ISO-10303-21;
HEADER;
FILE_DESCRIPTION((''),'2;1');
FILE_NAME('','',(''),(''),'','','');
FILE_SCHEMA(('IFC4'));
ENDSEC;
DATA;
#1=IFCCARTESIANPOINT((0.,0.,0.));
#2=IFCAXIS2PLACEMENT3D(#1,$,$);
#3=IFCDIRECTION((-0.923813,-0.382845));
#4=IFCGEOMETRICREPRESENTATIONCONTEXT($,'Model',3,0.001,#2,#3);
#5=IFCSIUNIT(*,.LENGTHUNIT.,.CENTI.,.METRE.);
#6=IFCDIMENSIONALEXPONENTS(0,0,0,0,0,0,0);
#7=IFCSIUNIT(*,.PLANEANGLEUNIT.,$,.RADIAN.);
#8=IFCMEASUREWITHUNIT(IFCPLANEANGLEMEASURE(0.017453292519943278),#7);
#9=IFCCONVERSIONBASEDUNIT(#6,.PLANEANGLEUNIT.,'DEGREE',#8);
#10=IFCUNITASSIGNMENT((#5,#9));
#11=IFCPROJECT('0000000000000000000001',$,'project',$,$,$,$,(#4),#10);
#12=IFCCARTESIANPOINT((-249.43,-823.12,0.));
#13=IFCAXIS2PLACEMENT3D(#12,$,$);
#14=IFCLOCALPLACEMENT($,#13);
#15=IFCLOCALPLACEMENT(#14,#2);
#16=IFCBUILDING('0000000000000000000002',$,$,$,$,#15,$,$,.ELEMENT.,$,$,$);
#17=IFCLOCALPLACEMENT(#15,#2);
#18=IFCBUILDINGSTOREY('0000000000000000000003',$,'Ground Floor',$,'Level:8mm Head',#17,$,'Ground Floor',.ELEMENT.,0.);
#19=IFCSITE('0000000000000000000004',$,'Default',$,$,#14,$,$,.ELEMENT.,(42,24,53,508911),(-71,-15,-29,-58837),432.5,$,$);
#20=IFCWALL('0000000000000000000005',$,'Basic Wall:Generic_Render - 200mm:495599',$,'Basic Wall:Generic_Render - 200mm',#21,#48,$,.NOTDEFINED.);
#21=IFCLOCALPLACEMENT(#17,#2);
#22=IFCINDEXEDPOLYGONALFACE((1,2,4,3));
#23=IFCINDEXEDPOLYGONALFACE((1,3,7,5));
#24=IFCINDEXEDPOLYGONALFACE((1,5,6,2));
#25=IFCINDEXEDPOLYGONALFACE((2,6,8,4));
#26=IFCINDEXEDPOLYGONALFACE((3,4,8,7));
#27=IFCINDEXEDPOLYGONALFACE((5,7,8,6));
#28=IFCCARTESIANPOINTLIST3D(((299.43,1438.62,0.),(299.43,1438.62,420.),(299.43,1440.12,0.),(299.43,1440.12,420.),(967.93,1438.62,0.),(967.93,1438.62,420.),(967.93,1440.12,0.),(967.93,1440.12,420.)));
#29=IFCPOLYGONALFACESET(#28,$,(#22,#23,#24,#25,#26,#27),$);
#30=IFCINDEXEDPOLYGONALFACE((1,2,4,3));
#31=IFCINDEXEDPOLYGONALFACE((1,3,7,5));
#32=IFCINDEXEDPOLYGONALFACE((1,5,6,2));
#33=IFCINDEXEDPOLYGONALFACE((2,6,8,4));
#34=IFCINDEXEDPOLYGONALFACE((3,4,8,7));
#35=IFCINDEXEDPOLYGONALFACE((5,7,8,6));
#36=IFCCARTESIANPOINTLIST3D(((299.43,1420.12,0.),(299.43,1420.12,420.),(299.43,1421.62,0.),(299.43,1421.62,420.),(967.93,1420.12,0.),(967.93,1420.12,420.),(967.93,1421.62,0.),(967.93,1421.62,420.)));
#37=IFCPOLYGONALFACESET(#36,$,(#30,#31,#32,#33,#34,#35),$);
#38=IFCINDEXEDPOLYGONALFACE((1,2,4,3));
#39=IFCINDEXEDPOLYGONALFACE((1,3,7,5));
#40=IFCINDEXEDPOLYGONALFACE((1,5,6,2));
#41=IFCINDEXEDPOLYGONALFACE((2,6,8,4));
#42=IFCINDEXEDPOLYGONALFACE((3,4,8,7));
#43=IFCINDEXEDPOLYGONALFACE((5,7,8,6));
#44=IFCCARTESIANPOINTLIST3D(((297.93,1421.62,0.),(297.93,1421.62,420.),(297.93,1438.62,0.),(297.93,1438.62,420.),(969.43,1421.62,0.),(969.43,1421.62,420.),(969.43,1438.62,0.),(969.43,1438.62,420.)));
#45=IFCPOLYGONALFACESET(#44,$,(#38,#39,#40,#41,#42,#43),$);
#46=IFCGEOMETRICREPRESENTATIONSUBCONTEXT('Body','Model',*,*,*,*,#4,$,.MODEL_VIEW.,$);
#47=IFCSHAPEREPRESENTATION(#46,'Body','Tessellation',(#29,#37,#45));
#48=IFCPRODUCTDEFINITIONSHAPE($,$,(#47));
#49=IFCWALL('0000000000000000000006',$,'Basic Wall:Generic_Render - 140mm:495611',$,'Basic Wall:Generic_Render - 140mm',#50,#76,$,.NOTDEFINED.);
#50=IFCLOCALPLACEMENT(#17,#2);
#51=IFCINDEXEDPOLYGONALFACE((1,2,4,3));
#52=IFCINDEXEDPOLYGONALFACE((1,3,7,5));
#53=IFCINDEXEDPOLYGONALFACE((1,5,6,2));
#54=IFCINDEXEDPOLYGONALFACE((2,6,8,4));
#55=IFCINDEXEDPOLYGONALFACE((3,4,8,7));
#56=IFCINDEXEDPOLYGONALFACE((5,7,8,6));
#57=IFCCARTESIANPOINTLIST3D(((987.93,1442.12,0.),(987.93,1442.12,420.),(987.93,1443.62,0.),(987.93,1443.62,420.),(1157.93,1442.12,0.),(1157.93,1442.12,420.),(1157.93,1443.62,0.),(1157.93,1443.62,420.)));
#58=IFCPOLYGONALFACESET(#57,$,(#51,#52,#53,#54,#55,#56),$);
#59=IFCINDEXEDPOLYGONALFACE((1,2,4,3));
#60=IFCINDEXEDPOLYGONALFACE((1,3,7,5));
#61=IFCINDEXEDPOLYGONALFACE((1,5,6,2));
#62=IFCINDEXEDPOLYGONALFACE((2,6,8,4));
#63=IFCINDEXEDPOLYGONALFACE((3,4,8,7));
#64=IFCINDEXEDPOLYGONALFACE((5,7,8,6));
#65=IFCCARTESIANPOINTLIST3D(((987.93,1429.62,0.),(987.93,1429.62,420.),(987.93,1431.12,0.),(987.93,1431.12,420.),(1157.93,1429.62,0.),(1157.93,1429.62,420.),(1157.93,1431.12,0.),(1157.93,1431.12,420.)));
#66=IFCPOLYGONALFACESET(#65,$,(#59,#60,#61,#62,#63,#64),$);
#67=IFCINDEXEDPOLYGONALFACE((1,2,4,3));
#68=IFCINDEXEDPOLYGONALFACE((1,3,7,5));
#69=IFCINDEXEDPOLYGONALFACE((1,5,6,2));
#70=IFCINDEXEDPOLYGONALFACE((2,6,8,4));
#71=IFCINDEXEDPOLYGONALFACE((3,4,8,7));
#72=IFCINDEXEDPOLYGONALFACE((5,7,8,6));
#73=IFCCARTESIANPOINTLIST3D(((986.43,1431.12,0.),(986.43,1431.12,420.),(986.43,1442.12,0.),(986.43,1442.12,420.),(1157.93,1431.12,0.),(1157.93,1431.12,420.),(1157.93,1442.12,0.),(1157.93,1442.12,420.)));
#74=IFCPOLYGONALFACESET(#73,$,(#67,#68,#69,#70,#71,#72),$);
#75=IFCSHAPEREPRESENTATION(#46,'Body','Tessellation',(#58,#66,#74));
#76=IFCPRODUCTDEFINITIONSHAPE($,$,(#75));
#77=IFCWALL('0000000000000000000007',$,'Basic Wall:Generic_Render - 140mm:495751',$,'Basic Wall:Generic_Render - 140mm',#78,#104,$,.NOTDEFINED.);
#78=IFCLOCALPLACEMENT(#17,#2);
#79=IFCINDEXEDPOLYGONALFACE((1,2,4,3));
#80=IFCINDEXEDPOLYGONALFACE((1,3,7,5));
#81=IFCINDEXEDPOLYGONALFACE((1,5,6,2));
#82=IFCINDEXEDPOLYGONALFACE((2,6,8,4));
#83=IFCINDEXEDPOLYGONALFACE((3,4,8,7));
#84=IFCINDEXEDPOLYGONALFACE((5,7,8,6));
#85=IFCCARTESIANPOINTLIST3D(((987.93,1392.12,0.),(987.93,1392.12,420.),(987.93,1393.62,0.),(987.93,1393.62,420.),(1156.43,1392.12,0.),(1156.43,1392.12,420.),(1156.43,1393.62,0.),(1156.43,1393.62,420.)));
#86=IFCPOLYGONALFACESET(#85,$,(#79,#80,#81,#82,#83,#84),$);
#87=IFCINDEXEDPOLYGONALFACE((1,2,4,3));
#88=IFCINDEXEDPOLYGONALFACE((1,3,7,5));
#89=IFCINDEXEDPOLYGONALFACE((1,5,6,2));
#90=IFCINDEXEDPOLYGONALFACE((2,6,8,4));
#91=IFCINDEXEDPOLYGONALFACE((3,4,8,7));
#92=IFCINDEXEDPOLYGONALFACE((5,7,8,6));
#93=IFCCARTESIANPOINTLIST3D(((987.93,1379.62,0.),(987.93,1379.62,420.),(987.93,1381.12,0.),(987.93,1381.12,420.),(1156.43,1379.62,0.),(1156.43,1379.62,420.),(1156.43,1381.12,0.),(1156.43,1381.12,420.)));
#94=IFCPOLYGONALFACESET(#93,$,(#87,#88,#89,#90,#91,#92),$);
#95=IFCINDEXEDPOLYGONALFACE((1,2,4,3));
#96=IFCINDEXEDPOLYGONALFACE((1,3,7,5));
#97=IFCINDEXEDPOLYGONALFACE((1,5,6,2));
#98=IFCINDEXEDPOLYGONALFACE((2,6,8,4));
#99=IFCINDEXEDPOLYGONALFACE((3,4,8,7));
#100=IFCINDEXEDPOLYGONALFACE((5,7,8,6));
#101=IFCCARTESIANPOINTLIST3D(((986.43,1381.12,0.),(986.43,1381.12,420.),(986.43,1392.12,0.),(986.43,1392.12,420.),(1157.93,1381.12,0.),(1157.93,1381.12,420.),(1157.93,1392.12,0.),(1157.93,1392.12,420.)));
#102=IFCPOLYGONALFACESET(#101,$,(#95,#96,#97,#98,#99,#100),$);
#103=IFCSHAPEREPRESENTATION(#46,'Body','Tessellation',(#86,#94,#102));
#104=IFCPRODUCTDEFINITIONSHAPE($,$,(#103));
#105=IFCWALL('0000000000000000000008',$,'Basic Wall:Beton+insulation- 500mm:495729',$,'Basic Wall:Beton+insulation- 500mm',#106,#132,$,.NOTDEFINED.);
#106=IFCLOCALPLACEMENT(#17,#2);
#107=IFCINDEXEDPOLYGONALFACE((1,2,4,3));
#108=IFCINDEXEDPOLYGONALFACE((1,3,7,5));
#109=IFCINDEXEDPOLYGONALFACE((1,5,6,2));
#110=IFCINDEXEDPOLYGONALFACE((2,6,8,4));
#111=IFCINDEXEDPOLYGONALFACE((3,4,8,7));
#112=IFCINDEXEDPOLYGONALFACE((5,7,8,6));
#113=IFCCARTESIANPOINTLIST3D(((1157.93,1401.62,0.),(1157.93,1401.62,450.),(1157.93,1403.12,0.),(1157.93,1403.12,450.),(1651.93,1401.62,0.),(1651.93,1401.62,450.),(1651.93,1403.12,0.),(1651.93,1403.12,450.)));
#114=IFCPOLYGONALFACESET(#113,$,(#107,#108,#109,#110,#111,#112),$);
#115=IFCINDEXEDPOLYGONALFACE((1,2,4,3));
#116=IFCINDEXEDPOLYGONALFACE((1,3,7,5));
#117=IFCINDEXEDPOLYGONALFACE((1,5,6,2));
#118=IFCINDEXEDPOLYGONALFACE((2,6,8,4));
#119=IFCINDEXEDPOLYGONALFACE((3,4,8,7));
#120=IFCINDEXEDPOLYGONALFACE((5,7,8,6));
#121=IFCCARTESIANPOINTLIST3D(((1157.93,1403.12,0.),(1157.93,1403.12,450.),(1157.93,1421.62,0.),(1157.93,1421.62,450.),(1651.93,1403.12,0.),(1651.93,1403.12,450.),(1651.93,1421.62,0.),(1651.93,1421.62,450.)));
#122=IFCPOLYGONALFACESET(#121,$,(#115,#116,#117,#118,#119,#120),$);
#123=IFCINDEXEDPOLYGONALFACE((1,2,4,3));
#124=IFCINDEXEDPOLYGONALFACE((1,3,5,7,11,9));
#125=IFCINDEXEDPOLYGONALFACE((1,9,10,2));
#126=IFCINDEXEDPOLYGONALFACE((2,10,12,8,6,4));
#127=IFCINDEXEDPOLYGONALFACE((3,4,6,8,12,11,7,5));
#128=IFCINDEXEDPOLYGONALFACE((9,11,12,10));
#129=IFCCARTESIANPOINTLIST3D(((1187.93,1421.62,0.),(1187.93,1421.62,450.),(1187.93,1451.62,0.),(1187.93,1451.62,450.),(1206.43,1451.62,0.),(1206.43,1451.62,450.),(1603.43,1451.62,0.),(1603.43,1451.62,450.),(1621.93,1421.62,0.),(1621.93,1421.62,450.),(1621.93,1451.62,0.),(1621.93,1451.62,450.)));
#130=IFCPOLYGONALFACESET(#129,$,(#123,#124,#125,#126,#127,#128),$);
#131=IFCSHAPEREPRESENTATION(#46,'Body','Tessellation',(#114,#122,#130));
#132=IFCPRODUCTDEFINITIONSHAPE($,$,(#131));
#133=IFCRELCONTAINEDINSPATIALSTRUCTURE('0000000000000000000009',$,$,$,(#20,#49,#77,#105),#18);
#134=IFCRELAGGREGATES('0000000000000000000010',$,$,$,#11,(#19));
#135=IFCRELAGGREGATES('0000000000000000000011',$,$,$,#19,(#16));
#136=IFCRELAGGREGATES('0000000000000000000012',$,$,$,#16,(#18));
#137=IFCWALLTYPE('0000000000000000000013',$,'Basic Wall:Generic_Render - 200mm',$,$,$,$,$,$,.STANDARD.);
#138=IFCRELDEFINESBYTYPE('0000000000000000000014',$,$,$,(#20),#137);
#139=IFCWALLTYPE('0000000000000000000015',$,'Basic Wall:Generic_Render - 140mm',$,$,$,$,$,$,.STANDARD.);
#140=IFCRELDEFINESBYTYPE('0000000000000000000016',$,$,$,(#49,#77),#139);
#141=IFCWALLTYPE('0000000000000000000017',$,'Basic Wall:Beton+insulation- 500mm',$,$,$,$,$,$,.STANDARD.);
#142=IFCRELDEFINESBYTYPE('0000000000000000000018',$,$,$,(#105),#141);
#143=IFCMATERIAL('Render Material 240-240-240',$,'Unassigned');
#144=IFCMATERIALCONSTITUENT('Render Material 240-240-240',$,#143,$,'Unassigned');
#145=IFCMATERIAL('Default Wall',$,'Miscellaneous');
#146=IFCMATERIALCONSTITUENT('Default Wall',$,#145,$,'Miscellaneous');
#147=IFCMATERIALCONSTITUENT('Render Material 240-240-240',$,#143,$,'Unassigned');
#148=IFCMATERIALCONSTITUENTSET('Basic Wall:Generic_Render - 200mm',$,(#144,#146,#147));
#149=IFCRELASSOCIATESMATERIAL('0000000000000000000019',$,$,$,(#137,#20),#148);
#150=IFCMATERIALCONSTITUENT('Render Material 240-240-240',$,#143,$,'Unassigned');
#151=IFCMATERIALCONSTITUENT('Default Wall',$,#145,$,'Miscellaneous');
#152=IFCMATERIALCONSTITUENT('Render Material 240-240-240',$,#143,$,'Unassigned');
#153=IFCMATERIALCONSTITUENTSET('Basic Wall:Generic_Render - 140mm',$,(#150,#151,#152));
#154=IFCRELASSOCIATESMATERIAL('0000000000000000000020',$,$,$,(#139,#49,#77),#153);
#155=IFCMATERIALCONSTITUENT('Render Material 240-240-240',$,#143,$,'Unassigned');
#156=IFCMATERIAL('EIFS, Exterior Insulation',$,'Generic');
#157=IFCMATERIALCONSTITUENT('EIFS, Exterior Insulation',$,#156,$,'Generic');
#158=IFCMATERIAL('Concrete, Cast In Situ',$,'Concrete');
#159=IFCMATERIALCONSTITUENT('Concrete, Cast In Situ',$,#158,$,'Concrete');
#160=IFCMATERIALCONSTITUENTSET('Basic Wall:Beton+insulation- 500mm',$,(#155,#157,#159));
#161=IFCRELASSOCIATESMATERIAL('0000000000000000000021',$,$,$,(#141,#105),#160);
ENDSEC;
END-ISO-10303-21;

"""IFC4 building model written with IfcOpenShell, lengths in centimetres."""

from ifc_helpers import new_model, entity, si_unit, converted_unit, direction, frame, origin, place, context, subcontext, project, spatial, indexed_curve, outline, extrude, material, constituent, constituent_set, type_object, element, save


model = new_model("IFC4")

# Units and contexts
model_context = context("Model", 3, precision=0.001, world=origin(), true_north=direction((-0.923813, -0.382845)))
body_context = subcontext(model_context, "Body", "Model", "MODEL_VIEW")
ifc_project = project(units=[si_unit("LENGTHUNIT", "METRE", prefix="CENTI"), converted_unit("PLANEANGLEUNIT", "DEGREE", entity("IfcPlaneAngleMeasure", 0.017453292519943278), si_unit("PLANEANGLEUNIT", "RADIAN"), dimensions=[0, 0, 0, 0, 0, 0, 0])], contexts=[model_context])

# Site, building, storey
site_placement = place(None, frame((-249.43, -823.12, 0.0)))
site = spatial("IfcSite", under=ifc_project, at=site_placement, Name="Default", CompositionType="ELEMENT", RefLatitude=(42, 24, 53, 508911), RefLongitude=(-71, -15, -29, -58837), RefElevation=432.5)
building_placement = place(site_placement, origin())
building = spatial("IfcBuilding", under=site, at=building_placement, CompositionType="ELEMENT")
storey_placement = place(building_placement, origin())
storey = spatial("IfcBuildingStorey", under=building, at=storey_placement, Name="Ground Floor", ObjectType="Level:8mm Head", LongName="Ground Floor", CompositionType="ELEMENT", Elevation=0.0)

# Wall
ifc_material_1 = material(Name="Concrete, Cast In Situ", Category="Concrete")
ifc_material_2 = material(Name="Render Material 240-240-240", Category="Unassigned")
ifc_material_3 = material(Name="Default Wall", Category="Miscellaneous")
ifc_material_4 = material(Name="EIFS, Exterior Insulation", Category="Generic")
ifc_constituent_1 = constituent(ifc_material_2, Name="Render Material 240-240-240", Category="Unassigned")
ifc_constituent_2 = constituent(ifc_material_3, Name="Default Wall", Category="Miscellaneous")
ifc_constituent_3 = constituent(ifc_material_2, Name="Render Material 240-240-240", Category="Unassigned")
ifc_constituent_set_1 = constituent_set(constituents=[ifc_constituent_1, ifc_constituent_2, ifc_constituent_3], Name="Basic Wall:Generic_Render - 200mm")
wall_type_1 = type_object("IfcWallType", Name="Basic Wall:Generic_Render - 200mm", PredefinedType="STANDARD", material=ifc_constituent_set_1)
wall_1_placement = place(storey_placement, frame((967.93, 1430.12, 0.0), z_axis=(0.0, 0.0, 1.0), x_axis=(-1.0, 0.0, 0.0)))
element("IfcWall", 1, at=wall_1_placement, inside=storey, type_object=wall_type_1, material=ifc_constituent_set_1, Name="Basic Wall:Generic_Render - 200mm:495599", ObjectType="Basic Wall:Generic_Render - 200mm", PredefinedType="NOTDEFINED", context=body_context, shape_type="SweptSolid", body=[
    extrude(outline(indexed_curve([(-0.75, -334.25), (0.75, -334.25), (0.75, 334.25), (-0.75, 334.25), (-0.75, -334.25)], self_intersect=False)), frame((334.25, -9.25, 0.0), z_axis=(0.0, 0.0, 1.0), x_axis=(0.0, 1.0, 0.0)), (0.0, 0.0, 1.0), 420.0),
    extrude(outline(indexed_curve([(-0.75, -334.25), (0.75, -334.25), (0.75, 334.25), (-0.75, 334.25), (-0.75, -334.25)], self_intersect=False)), frame((334.25, 9.25, 0.0), z_axis=(0.0, 0.0, 1.0), x_axis=(0.0, -1.0, 0.0)), (0.0, 0.0, 1.0), 420.0),
    extrude(outline(indexed_curve([(-335.75, -8.5), (335.75, -8.5), (335.75, 8.5), (-335.75, 8.5), (-335.75, -8.5)], self_intersect=False)), frame((334.25, 0.0, 0.0)), (0.0, 0.0, 1.0), 420.0),
])

# Walls
ifc_constituent_4 = constituent(ifc_material_2, Name="Render Material 240-240-240", Category="Unassigned")
ifc_constituent_5 = constituent(ifc_material_3, Name="Default Wall", Category="Miscellaneous")
ifc_constituent_6 = constituent(ifc_material_2, Name="Render Material 240-240-240", Category="Unassigned")
ifc_constituent_set_2 = constituent_set(constituents=[ifc_constituent_4, ifc_constituent_5, ifc_constituent_6], Name="Basic Wall:Generic_Render - 140mm")
wall_type_2 = type_object("IfcWallType", Name="Basic Wall:Generic_Render - 140mm", PredefinedType="STANDARD", material=ifc_constituent_set_2)
wall_2_placement = place(storey_placement, frame((1157.93, 1436.62, 0.0), z_axis=(0.0, 0.0, 1.0), x_axis=(-1.0, 0.0, 0.0)))
element("IfcWall", 2, at=wall_2_placement, inside=storey, type_object=wall_type_2, material=ifc_constituent_set_2, Name="Basic Wall:Generic_Render - 140mm:495611", ObjectType="Basic Wall:Generic_Render - 140mm", PredefinedType="NOTDEFINED", context=body_context, shape_type="SweptSolid", body=[
    extrude(outline(indexed_curve([(-0.75, -85.0), (0.75, -85.0), (0.75, 85.0), (-0.75, 85.0), (-0.75, -85.0)], self_intersect=False)), frame((85.0, -6.25, 0.0), z_axis=(0.0, 0.0, 1.0), x_axis=(0.0, 1.0, 0.0)), (0.0, 0.0, 1.0), 420.0),
    extrude(outline(indexed_curve([(-0.75, -85.0), (0.75, -85.0), (0.75, 85.0), (-0.75, 85.0), (-0.75, -85.0)], self_intersect=False)), frame((85.0, 6.25, 0.0), z_axis=(0.0, 0.0, 1.0), x_axis=(0.0, -1.0, 0.0)), (0.0, 0.0, 1.0), 420.0),
    extrude(outline(indexed_curve([(-85.75, -5.5), (85.75, -5.5), (85.75, 5.5), (-85.75, 5.5), (-85.75, -5.5)], self_intersect=False)), frame((85.75, 0.0, 0.0)), (0.0, 0.0, 1.0), 420.0),
])
wall_3_placement = place(storey_placement, frame((1156.43, 1386.62, 0.0), z_axis=(0.0, 0.0, 1.0), x_axis=(-1.0, 0.0, 0.0)))
element("IfcWall", 3, at=wall_3_placement, inside=storey, type_object=wall_type_2, material=ifc_constituent_set_2, Name="Basic Wall:Generic_Render - 140mm:495751", ObjectType="Basic Wall:Generic_Render - 140mm", PredefinedType="NOTDEFINED", context=body_context, shape_type="SweptSolid", body=[
    extrude(outline(indexed_curve([(-0.75, -84.25), (0.75, -84.25), (0.75, 84.25), (-0.75, 84.25), (-0.75, -84.25)], self_intersect=False)), frame((84.25, -6.25, 0.0), z_axis=(0.0, 0.0, 1.0), x_axis=(0.0, 1.0, 0.0)), (0.0, 0.0, 1.0), 420.0),
    extrude(outline(indexed_curve([(-0.75, -84.25), (0.75, -84.25), (0.75, 84.25), (-0.75, 84.25), (-0.75, -84.25)], self_intersect=False)), frame((84.25, 6.25, 0.0), z_axis=(0.0, 0.0, 1.0), x_axis=(0.0, -1.0, 0.0)), (0.0, 0.0, 1.0), 420.0),
    extrude(outline(indexed_curve([(-85.75, -5.5), (85.75, -5.5), (85.75, 5.5), (-85.75, 5.5), (-85.75, -5.5)], self_intersect=False)), frame((84.25, 0.0, 0.0)), (0.0, 0.0, 1.0), 420.0),
])
ifc_constituent_7 = constituent(ifc_material_2, Name="Render Material 240-240-240", Category="Unassigned")
ifc_constituent_8 = constituent(ifc_material_4, Name="EIFS, Exterior Insulation", Category="Generic")
ifc_constituent_9 = constituent(ifc_material_1, Name="Concrete, Cast In Situ", Category="Concrete")
ifc_constituent_set_3 = constituent_set(constituents=[ifc_constituent_7, ifc_constituent_8, ifc_constituent_9], Name="Basic Wall:Beton+insulation- 500mm")
wall_type_3 = type_object("IfcWallType", Name="Basic Wall:Beton+insulation- 500mm", PredefinedType="STANDARD", material=ifc_constituent_set_3)
wall_4_placement = place(storey_placement, frame((1187.93, 1426.62, 0.0)))
element("IfcWall", 4, at=wall_4_placement, inside=storey, type_object=wall_type_3, material=ifc_constituent_set_3, Name="Basic Wall:Beton+insulation- 500mm:495729", ObjectType="Basic Wall:Beton+insulation- 500mm", PredefinedType="NOTDEFINED", context=body_context, shape_type="SweptSolid", body=[
    extrude(outline(indexed_curve([(-0.75, -247.0), (0.75, -247.0), (0.75, 247.0), (-0.75, 247.0), (-0.75, -247.0)], self_intersect=False)), frame((217.0, -24.25, 0.0), z_axis=(0.0, 0.0, 1.0), x_axis=(0.0, 1.0, 0.0)), (0.0, 0.0, 1.0), 450.0),
    extrude(outline(indexed_curve([(-9.25, -247.0), (9.25, -247.0), (9.25, 247.0), (-9.25, 247.0), (-9.25, -247.0)], self_intersect=False)), frame((217.0, -14.25, 0.0), z_axis=(0.0, 0.0, 1.0), x_axis=(0.0, -1.0, 0.0)), (0.0, 0.0, 1.0), 450.0),
    extrude(outline(indexed_curve([(-20.0, -217.0), (10.0, -217.0), (10.0, -198.5), (10.0, 198.5), (10.0, 217.0), (-20.0, 217.0), (-20.0, -217.0)], self_intersect=False)), frame((217.0, 15.0, 0.0), z_axis=(0.0, 0.0, 1.0), x_axis=(0.0, 1.0, 0.0)), (0.0, 0.0, 1.0), 450.0),
])

save(model, "model.ifc")
